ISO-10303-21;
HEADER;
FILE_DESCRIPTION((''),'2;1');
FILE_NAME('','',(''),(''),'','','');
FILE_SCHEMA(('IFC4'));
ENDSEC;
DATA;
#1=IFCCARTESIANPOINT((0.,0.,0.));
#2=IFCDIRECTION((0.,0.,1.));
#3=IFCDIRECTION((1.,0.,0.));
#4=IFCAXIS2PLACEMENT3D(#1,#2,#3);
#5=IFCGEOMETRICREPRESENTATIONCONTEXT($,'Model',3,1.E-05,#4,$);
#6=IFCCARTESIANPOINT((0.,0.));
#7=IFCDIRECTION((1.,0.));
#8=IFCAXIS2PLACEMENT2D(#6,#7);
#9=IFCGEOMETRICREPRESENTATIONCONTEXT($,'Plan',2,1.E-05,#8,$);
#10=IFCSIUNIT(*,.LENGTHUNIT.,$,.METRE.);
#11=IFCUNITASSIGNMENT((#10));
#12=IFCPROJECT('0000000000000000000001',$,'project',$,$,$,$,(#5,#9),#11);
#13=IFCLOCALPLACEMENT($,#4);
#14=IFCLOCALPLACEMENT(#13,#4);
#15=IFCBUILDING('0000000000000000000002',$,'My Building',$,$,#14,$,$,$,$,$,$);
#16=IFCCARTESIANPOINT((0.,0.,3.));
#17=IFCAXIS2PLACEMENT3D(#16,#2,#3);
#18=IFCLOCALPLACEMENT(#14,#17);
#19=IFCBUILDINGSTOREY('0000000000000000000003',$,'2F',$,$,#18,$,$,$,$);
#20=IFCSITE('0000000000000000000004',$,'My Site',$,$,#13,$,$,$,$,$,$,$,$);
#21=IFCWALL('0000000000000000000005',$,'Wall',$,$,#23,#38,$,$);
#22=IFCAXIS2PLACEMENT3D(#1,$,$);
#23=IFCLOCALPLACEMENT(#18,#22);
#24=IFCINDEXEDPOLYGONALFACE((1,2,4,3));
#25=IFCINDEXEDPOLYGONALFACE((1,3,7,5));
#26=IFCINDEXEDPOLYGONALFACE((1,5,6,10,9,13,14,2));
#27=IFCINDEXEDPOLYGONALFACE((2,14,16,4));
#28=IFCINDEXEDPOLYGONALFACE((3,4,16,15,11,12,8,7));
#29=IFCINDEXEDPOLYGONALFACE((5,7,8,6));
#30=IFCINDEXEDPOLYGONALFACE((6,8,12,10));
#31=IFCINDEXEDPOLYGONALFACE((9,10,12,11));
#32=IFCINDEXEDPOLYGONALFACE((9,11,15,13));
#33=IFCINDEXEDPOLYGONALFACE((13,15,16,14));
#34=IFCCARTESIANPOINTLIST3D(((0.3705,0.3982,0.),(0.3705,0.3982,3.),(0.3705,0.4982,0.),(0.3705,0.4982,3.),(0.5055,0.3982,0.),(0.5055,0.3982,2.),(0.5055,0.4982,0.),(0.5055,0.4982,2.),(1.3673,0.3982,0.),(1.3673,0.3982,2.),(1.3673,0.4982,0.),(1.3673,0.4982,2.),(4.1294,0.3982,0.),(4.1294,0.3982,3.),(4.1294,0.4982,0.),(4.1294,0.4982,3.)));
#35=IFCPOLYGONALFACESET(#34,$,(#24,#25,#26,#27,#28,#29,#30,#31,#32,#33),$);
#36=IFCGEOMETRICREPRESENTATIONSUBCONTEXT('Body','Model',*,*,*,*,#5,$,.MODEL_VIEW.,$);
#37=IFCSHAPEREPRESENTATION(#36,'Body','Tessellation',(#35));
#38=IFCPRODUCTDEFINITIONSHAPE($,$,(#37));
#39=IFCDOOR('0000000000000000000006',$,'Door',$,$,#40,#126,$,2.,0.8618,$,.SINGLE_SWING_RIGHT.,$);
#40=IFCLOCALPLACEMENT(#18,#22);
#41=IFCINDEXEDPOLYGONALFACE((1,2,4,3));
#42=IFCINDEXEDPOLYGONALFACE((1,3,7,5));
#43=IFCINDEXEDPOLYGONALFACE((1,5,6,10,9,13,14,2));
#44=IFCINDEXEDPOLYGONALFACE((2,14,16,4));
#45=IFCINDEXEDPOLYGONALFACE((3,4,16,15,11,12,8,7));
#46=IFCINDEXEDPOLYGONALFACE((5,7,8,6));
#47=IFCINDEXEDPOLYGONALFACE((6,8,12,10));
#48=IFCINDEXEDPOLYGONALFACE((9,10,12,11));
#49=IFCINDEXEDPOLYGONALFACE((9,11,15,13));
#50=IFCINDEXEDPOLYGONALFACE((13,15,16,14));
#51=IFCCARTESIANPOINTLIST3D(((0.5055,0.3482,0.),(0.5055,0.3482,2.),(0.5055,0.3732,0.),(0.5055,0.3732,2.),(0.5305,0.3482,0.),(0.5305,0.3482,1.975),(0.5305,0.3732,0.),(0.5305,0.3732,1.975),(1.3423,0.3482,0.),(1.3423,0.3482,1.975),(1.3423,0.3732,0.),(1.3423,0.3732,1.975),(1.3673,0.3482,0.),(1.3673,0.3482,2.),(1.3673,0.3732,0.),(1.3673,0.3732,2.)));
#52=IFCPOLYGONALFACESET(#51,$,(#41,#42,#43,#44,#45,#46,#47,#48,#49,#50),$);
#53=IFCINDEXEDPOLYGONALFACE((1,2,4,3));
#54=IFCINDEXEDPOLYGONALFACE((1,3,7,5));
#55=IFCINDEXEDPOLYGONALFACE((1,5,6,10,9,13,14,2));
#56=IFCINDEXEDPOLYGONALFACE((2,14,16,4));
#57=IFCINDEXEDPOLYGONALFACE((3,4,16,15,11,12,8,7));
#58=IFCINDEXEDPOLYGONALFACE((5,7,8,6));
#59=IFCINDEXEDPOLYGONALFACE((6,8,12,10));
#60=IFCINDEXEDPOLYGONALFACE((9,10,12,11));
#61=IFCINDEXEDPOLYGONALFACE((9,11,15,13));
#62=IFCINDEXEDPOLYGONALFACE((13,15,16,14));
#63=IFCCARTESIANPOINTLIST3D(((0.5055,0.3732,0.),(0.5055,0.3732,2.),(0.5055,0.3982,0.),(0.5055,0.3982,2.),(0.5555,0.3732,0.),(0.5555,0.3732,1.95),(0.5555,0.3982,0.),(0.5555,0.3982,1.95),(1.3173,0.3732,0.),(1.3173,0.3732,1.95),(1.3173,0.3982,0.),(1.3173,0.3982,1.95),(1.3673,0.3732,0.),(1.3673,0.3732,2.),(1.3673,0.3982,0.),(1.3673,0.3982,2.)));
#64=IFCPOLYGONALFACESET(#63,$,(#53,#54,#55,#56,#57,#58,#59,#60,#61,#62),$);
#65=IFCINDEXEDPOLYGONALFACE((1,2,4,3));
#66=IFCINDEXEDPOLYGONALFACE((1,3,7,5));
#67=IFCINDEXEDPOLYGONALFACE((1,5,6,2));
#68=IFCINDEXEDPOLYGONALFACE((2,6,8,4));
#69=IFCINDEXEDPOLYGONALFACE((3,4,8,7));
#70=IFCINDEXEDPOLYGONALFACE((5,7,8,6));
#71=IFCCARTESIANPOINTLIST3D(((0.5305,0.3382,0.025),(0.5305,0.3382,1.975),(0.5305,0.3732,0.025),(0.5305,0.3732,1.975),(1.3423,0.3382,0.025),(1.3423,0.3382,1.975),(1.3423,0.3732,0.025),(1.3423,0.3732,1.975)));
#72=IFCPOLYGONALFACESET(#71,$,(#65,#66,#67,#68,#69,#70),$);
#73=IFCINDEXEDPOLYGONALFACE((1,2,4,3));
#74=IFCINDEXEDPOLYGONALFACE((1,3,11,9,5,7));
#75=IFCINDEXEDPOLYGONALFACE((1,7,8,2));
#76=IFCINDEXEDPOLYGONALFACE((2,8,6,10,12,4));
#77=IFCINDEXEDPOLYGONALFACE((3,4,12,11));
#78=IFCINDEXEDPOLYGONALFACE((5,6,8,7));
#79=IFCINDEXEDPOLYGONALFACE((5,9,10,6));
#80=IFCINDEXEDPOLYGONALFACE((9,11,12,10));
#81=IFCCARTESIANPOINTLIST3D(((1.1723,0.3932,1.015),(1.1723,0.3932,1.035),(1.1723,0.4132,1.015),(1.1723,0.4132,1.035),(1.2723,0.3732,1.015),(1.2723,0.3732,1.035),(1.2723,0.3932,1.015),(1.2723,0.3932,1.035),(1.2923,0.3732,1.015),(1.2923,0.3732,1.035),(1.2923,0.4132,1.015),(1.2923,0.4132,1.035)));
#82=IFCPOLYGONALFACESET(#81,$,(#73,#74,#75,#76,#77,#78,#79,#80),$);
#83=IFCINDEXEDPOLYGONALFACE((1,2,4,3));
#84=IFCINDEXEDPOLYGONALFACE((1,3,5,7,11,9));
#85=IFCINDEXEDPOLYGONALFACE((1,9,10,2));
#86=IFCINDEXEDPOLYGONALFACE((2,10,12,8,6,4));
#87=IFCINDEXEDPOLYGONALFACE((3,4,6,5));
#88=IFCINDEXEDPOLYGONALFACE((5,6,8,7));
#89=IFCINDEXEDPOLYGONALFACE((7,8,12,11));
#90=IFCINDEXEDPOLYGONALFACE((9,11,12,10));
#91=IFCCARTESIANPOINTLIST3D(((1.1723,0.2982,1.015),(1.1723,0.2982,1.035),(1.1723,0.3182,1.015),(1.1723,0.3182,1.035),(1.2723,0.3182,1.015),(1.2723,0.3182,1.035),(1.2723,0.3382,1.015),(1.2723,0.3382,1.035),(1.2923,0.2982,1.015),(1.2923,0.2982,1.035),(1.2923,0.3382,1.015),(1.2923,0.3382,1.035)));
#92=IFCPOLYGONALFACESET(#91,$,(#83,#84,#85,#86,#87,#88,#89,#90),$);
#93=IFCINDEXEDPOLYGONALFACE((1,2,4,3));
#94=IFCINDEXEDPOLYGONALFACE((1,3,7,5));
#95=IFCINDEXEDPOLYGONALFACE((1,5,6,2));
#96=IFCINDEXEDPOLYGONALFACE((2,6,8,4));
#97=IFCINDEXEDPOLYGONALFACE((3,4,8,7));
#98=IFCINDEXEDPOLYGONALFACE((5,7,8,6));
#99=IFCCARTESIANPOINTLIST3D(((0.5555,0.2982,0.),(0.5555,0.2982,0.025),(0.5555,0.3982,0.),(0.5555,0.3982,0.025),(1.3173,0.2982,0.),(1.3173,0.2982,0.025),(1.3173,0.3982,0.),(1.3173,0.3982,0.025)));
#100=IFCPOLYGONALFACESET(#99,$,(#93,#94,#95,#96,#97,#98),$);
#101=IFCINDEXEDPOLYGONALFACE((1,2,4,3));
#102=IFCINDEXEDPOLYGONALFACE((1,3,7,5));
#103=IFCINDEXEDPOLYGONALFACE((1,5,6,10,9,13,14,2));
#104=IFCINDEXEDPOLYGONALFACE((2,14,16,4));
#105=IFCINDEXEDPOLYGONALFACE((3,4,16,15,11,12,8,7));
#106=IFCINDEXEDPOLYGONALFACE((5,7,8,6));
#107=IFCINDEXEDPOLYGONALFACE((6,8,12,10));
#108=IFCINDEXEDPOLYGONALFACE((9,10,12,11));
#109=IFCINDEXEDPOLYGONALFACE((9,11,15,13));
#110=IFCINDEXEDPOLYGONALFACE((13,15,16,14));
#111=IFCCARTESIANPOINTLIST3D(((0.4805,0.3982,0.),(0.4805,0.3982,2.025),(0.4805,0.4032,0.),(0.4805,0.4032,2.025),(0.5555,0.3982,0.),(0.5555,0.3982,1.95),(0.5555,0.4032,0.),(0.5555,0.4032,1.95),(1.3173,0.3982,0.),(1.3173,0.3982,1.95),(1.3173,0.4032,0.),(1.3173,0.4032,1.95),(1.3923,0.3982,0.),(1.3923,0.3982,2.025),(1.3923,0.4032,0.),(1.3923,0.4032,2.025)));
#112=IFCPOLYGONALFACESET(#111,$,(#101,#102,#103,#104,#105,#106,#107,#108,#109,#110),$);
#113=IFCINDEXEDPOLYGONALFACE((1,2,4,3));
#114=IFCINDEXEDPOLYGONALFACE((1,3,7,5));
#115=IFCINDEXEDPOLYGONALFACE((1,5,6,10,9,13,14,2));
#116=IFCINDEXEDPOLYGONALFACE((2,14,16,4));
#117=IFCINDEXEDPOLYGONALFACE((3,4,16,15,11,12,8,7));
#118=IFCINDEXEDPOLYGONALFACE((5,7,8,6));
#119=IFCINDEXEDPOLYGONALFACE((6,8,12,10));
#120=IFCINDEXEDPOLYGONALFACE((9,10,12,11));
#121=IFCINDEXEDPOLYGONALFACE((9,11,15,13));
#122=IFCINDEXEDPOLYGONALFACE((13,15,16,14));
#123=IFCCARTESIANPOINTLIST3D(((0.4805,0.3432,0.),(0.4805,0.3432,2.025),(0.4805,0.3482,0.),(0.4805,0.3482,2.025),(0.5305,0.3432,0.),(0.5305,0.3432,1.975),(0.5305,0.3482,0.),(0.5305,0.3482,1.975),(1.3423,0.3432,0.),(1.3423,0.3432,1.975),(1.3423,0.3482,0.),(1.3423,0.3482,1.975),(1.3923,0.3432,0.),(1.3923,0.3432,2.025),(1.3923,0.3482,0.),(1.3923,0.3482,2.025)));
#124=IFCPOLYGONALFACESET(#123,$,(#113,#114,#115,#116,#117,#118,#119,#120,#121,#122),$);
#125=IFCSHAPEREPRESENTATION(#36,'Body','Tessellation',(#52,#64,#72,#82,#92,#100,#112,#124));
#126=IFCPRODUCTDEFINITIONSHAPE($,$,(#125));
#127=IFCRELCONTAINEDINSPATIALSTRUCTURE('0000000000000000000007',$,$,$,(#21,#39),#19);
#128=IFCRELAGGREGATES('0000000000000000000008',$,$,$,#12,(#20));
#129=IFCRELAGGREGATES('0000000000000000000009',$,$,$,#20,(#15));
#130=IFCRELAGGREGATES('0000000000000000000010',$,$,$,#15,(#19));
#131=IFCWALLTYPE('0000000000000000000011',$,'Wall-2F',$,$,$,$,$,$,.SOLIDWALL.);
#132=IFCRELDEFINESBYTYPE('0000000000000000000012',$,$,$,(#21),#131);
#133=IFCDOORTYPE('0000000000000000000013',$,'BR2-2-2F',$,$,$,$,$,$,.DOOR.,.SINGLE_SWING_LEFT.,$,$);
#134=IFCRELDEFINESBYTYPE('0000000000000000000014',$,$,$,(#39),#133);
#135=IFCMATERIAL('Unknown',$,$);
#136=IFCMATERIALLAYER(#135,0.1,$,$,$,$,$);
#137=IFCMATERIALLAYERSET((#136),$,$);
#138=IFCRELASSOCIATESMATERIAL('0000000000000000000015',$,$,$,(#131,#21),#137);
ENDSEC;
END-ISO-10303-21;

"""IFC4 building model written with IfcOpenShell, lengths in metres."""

from ifc_helpers import new_model, entity, si_unit, frame, origin_with_axes, origin_2d_with_axis, place, context, subcontext, project, spatial, line, indexed_curve, outline, extrude, shape, source, transform, mapped, material, layer, layer_set, layer_usage, type_object, type_shapes, element, fill, save


model = new_model("IFC4")

# Units and contexts
model_context = context("Model", 3, precision=1e-05, world=origin_with_axes())
plan_context = context("Plan", 2, precision=1e-05, world=origin_2d_with_axis())
body_context_1 = subcontext(model_context, "Body", "Model", "MODEL_VIEW")
body_context_2 = subcontext(plan_context, "Body", "Plan", "PLAN_VIEW")
ifc_project = project(units=[si_unit("LENGTHUNIT", "METRE")], contexts=[model_context, plan_context])

# Site, building, storey
site_placement = place(None, origin_with_axes())
site = spatial("IfcSite", under=ifc_project, at=site_placement, Name="My Site")
building_placement = place(site_placement, origin_with_axes())
building = spatial("IfcBuilding", under=site, at=building_placement, Name="My Building")
storey_placement = place(building_placement, frame((0.0, 0.0, 3.0), z_axis=(0.0, 0.0, 1.0), x_axis=(1.0, 0.0, 0.0)))
storey = spatial("IfcBuildingStorey", under=building, at=storey_placement, Name="2F")

# Shared definitions
ifc_material = material(Name="Unknown")
ifc_layer = layer(ifc_material, 0.1)
ifc_layer_set = layer_set([ifc_layer])
wall_type = type_object("IfcWallType", Name="Wall-2F", PredefinedType="SOLIDWALL", material=ifc_layer_set)

# Wall, opening, door
ifc_layer_usage_1 = layer_usage(ifc_layer_set, "AXIS2", "NEGATIVE", 0.0)
wall_1_placement = place(storey_placement, frame((0.3705, 0.4982, 0.0), z_axis=(0.0, 0.0, 1.0), x_axis=(1.0, 0.0, 0.0)))
wall_1 = element("IfcWall", 1, at=wall_1_placement, inside=storey, type_object=wall_type, material=ifc_layer_usage_1, Name="Wall", context=body_context_1, shape_type="SweptSolid", body=[
    extrude(outline(indexed_curve([(0.0, -0.1), (0.0, 0.0), (3.7589, 0.0), (3.7589, -0.1)], segments=[line(1, 2, 3, 4, 1)])), origin_with_axes(), (0.0, 0.0, 1.0), 3.0),
])
shared_shape_1 = source(origin_with_axes(), body_context_1, "Body", "SweptSolid", [
    extrude(outline(indexed_curve([(0.0, 0.0), (0.8618, 0.0), (0.8618, 2.0), (0.0, 2.0)], segments=[line(1, 2, 3, 4, 1)])), frame((0.0, -0.6, 0.0), z_axis=(0.0, -1.0, 0.0), x_axis=(1.0, 0.0, 0.0)), (0.0, 0.0, -1.0), 1.2),
])
opening_1_placement = place(wall_1_placement, frame((0.9968, -0.1, 0.0), z_axis=(0.0, 0.0, 1.0), x_axis=(-1.0, 0.0, 0.0)))
opening_1 = element("IfcOpeningElement", 2, at=opening_1_placement, cuts=wall_1, PredefinedType="OPENING", context=body_context_1, shape_type="MappedRepresentation", body=[
    mapped(shared_shape_1, transform((0.0, 0.0, 0.0), x_axis=(1.0, 0.0, 0.0), y_axis=(0.0, 1.0, 0.0), z_axis=(0.0, 0.0, 1.0), scale=1.0)),
])
door_type_1 = type_object("IfcDoorType", Name="BR2-2-2F", OperationType="SINGLE_SWING_LEFT", PredefinedType="DOOR")
shared_shape_2 = source(origin_with_axes(), body_context_1, "Body", "SweptSolid", [
    extrude(outline(indexed_curve([(0.0, 0.0), (0.0, 2.0), (0.8618, 2.0), (0.8618, 0.0), (0.8368, 0.0), (0.8368, 1.975), (0.025, 1.975), (0.025, 0.0)], segments=[line(1, 2, 3, 4, 5, 6, 7, 8, 1)])), frame((0.0, 0.025, 0.0), z_axis=(0.0, -1.0, 0.0), x_axis=(1.0, 0.0, 0.0)), (0.0, 0.0, -1.0), 0.025),
    extrude(outline(indexed_curve([(0.0, 0.0), (0.0, 2.0), (0.8618, 2.0), (0.8618, 0.0), (0.8118, 0.0), (0.8118, 1.95), (0.05, 1.95), (0.05, 0.0)], segments=[line(1, 2, 3, 4, 5, 6, 7, 8, 1)])), frame((0.0, 0.0, 0.0), z_axis=(0.0, -1.0, 0.0), x_axis=(1.0, 0.0, 0.0)), (0.0, 0.0, -1.0), 0.025),
    extrude(outline(indexed_curve([(0.0, 0.0), (0.8118, 0.0), (0.8118, 0.035), (0.0, 0.035)], segments=[line(1, 2, 3, 4, 1)])), frame((0.025, 0.025, 0.025), z_axis=(0.0, 0.0, 1.0), x_axis=(1.0, 0.0, 0.0)), (0.0, 0.0, 1.0), 1.95),
    extrude(outline(indexed_curve([(0.0, 0.0), (0.0, -0.04), (0.12, -0.04), (0.12, -0.02), (0.02, -0.02), (0.02, 0.0)], segments=[line(1, 2, 3, 4, 5, 6, 1)])), frame((0.075, 0.025, 1.015), z_axis=(0.0, 0.0, 1.0), x_axis=(1.0, 0.0, 0.0)), (0.0, 0.0, 1.0), 0.02),
    extrude(outline(indexed_curve([(0.0, 0.0), (0.0, 0.04), (0.12, 0.04), (0.12, 0.02), (0.02, 0.02), (0.02, 0.0)], segments=[line(1, 2, 3, 4, 5, 6, 1)])), frame((0.075, 0.06, 1.015), z_axis=(0.0, 0.0, 1.0), x_axis=(1.0, 0.0, 0.0)), (0.0, 0.0, 1.0), 0.02),
    extrude(outline(indexed_curve([(0.0, 0.0), (0.7618, 0.0), (0.7618, 0.1), (0.0, 0.1)], segments=[line(1, 2, 3, 4, 1)])), frame((0.05, 0.0, 0.0), z_axis=(0.0, 0.0, 1.0), x_axis=(1.0, 0.0, 0.0)), (0.0, 0.0, 1.0), 0.025),
    extrude(outline(indexed_curve([(0.0, 0.0), (0.0, 2.025), (0.9118, 2.025), (0.9118, 0.0), (0.8368, 0.0), (0.8368, 1.95), (0.075, 1.95), (0.075, 0.0)], segments=[line(1, 2, 3, 4, 5, 6, 7, 8, 1)])), frame((-0.025, -0.005, 0.0), z_axis=(0.0, -1.0, 0.0), x_axis=(1.0, 0.0, 0.0)), (0.0, 0.0, -1.0), 0.005),
    extrude(outline(indexed_curve([(0.0, 0.0), (0.0, 2.025), (0.9118, 2.025), (0.9118, 0.0), (0.8618, 0.0), (0.8618, 1.975), (0.05, 1.975), (0.05, 0.0)], segments=[line(1, 2, 3, 4, 5, 6, 7, 8, 1)])), frame((-0.025, 0.05, 0.0), z_axis=(0.0, -1.0, 0.0), x_axis=(1.0, 0.0, 0.0)), (0.0, 0.0, -1.0), 0.005),
])
shared_shape_3 = source(origin_with_axes(), body_context_2, "Body", "Curve2D", [
    entity("IfcIndexedPolyCurve", entity("IfcCartesianPointList2D", [[0.0, 0.0], [0.0, 0.05], [0.025, 0.05], [0.025, 0.025], [0.05, 0.025], [0.05, 0.0]]), [entity("IfcLineIndex", [1, 2, 3, 4, 5, 6, 1])]),
    entity("IfcIndexedPolyCurve", entity("IfcCartesianPointList2D", [[0.8618, 0.0], [0.8618, 0.05], [0.8368, 0.05], [0.8368, 0.025], [0.8118, 0.025], [0.8118, 0.0]]), [entity("IfcLineIndex", [1, 2, 3, 4, 5, 6, 1])]),
    entity("IfcTrimmedCurve", entity("IfcEllipse", entity("IfcAxis2Placement2D", entity("IfcCartesianPoint", [0.8018, 0.05]), entity("IfcDirection", [1.0, 0.0])), 0.7768, 0.8118), [entity("IfcCartesianPoint", [0.8018, 0.8618])], [entity("IfcCartesianPoint", [0.025, 0.05])], True, "CARTESIAN"),
    entity("IfcIndexedPolyCurve", entity("IfcCartesianPointList2D", [[0.8368, 0.05], [0.8018, 0.05], [0.8018, 0.8618], [0.8368, 0.8618]]), [entity("IfcLineIndex", [1, 2, 3, 4, 1])]),
])
type_shapes(door_type_1, [shared_shape_2, shared_shape_3])
door_1_placement = place(opening_1_placement, frame((0.0, 0.0, 0.0), z_axis=(0.0, 0.0, 1.0), x_axis=(1.0, 0.0, 0.0)))
door_1 = element("IfcDoor", 3, at=door_1_placement, inside=storey, type_object=door_type_1, Name="Door", OperationType="SINGLE_SWING_RIGHT", OverallHeight=2.0, OverallWidth=0.8618, shapes=[
    shape(body_context_1, "Body", "MappedRepresentation", [mapped(shared_shape_2, transform((0.0, 0.0, 0.0), x_axis=(1.0, 0.0, 0.0), y_axis=(0.0, 1.0, 0.0), z_axis=(0.0, 0.0, 1.0), scale=1.0))]),
    shape(body_context_2, "Body", "MappedRepresentation", [mapped(shared_shape_3, transform((0.0, 0.0, 0.0), x_axis=(1.0, 0.0, 0.0), y_axis=(0.0, 1.0, 0.0), z_axis=(0.0, 0.0, 1.0), scale=1.0))]),
])
fill(opening_1, door_1)

save(model, "model.ifc")
